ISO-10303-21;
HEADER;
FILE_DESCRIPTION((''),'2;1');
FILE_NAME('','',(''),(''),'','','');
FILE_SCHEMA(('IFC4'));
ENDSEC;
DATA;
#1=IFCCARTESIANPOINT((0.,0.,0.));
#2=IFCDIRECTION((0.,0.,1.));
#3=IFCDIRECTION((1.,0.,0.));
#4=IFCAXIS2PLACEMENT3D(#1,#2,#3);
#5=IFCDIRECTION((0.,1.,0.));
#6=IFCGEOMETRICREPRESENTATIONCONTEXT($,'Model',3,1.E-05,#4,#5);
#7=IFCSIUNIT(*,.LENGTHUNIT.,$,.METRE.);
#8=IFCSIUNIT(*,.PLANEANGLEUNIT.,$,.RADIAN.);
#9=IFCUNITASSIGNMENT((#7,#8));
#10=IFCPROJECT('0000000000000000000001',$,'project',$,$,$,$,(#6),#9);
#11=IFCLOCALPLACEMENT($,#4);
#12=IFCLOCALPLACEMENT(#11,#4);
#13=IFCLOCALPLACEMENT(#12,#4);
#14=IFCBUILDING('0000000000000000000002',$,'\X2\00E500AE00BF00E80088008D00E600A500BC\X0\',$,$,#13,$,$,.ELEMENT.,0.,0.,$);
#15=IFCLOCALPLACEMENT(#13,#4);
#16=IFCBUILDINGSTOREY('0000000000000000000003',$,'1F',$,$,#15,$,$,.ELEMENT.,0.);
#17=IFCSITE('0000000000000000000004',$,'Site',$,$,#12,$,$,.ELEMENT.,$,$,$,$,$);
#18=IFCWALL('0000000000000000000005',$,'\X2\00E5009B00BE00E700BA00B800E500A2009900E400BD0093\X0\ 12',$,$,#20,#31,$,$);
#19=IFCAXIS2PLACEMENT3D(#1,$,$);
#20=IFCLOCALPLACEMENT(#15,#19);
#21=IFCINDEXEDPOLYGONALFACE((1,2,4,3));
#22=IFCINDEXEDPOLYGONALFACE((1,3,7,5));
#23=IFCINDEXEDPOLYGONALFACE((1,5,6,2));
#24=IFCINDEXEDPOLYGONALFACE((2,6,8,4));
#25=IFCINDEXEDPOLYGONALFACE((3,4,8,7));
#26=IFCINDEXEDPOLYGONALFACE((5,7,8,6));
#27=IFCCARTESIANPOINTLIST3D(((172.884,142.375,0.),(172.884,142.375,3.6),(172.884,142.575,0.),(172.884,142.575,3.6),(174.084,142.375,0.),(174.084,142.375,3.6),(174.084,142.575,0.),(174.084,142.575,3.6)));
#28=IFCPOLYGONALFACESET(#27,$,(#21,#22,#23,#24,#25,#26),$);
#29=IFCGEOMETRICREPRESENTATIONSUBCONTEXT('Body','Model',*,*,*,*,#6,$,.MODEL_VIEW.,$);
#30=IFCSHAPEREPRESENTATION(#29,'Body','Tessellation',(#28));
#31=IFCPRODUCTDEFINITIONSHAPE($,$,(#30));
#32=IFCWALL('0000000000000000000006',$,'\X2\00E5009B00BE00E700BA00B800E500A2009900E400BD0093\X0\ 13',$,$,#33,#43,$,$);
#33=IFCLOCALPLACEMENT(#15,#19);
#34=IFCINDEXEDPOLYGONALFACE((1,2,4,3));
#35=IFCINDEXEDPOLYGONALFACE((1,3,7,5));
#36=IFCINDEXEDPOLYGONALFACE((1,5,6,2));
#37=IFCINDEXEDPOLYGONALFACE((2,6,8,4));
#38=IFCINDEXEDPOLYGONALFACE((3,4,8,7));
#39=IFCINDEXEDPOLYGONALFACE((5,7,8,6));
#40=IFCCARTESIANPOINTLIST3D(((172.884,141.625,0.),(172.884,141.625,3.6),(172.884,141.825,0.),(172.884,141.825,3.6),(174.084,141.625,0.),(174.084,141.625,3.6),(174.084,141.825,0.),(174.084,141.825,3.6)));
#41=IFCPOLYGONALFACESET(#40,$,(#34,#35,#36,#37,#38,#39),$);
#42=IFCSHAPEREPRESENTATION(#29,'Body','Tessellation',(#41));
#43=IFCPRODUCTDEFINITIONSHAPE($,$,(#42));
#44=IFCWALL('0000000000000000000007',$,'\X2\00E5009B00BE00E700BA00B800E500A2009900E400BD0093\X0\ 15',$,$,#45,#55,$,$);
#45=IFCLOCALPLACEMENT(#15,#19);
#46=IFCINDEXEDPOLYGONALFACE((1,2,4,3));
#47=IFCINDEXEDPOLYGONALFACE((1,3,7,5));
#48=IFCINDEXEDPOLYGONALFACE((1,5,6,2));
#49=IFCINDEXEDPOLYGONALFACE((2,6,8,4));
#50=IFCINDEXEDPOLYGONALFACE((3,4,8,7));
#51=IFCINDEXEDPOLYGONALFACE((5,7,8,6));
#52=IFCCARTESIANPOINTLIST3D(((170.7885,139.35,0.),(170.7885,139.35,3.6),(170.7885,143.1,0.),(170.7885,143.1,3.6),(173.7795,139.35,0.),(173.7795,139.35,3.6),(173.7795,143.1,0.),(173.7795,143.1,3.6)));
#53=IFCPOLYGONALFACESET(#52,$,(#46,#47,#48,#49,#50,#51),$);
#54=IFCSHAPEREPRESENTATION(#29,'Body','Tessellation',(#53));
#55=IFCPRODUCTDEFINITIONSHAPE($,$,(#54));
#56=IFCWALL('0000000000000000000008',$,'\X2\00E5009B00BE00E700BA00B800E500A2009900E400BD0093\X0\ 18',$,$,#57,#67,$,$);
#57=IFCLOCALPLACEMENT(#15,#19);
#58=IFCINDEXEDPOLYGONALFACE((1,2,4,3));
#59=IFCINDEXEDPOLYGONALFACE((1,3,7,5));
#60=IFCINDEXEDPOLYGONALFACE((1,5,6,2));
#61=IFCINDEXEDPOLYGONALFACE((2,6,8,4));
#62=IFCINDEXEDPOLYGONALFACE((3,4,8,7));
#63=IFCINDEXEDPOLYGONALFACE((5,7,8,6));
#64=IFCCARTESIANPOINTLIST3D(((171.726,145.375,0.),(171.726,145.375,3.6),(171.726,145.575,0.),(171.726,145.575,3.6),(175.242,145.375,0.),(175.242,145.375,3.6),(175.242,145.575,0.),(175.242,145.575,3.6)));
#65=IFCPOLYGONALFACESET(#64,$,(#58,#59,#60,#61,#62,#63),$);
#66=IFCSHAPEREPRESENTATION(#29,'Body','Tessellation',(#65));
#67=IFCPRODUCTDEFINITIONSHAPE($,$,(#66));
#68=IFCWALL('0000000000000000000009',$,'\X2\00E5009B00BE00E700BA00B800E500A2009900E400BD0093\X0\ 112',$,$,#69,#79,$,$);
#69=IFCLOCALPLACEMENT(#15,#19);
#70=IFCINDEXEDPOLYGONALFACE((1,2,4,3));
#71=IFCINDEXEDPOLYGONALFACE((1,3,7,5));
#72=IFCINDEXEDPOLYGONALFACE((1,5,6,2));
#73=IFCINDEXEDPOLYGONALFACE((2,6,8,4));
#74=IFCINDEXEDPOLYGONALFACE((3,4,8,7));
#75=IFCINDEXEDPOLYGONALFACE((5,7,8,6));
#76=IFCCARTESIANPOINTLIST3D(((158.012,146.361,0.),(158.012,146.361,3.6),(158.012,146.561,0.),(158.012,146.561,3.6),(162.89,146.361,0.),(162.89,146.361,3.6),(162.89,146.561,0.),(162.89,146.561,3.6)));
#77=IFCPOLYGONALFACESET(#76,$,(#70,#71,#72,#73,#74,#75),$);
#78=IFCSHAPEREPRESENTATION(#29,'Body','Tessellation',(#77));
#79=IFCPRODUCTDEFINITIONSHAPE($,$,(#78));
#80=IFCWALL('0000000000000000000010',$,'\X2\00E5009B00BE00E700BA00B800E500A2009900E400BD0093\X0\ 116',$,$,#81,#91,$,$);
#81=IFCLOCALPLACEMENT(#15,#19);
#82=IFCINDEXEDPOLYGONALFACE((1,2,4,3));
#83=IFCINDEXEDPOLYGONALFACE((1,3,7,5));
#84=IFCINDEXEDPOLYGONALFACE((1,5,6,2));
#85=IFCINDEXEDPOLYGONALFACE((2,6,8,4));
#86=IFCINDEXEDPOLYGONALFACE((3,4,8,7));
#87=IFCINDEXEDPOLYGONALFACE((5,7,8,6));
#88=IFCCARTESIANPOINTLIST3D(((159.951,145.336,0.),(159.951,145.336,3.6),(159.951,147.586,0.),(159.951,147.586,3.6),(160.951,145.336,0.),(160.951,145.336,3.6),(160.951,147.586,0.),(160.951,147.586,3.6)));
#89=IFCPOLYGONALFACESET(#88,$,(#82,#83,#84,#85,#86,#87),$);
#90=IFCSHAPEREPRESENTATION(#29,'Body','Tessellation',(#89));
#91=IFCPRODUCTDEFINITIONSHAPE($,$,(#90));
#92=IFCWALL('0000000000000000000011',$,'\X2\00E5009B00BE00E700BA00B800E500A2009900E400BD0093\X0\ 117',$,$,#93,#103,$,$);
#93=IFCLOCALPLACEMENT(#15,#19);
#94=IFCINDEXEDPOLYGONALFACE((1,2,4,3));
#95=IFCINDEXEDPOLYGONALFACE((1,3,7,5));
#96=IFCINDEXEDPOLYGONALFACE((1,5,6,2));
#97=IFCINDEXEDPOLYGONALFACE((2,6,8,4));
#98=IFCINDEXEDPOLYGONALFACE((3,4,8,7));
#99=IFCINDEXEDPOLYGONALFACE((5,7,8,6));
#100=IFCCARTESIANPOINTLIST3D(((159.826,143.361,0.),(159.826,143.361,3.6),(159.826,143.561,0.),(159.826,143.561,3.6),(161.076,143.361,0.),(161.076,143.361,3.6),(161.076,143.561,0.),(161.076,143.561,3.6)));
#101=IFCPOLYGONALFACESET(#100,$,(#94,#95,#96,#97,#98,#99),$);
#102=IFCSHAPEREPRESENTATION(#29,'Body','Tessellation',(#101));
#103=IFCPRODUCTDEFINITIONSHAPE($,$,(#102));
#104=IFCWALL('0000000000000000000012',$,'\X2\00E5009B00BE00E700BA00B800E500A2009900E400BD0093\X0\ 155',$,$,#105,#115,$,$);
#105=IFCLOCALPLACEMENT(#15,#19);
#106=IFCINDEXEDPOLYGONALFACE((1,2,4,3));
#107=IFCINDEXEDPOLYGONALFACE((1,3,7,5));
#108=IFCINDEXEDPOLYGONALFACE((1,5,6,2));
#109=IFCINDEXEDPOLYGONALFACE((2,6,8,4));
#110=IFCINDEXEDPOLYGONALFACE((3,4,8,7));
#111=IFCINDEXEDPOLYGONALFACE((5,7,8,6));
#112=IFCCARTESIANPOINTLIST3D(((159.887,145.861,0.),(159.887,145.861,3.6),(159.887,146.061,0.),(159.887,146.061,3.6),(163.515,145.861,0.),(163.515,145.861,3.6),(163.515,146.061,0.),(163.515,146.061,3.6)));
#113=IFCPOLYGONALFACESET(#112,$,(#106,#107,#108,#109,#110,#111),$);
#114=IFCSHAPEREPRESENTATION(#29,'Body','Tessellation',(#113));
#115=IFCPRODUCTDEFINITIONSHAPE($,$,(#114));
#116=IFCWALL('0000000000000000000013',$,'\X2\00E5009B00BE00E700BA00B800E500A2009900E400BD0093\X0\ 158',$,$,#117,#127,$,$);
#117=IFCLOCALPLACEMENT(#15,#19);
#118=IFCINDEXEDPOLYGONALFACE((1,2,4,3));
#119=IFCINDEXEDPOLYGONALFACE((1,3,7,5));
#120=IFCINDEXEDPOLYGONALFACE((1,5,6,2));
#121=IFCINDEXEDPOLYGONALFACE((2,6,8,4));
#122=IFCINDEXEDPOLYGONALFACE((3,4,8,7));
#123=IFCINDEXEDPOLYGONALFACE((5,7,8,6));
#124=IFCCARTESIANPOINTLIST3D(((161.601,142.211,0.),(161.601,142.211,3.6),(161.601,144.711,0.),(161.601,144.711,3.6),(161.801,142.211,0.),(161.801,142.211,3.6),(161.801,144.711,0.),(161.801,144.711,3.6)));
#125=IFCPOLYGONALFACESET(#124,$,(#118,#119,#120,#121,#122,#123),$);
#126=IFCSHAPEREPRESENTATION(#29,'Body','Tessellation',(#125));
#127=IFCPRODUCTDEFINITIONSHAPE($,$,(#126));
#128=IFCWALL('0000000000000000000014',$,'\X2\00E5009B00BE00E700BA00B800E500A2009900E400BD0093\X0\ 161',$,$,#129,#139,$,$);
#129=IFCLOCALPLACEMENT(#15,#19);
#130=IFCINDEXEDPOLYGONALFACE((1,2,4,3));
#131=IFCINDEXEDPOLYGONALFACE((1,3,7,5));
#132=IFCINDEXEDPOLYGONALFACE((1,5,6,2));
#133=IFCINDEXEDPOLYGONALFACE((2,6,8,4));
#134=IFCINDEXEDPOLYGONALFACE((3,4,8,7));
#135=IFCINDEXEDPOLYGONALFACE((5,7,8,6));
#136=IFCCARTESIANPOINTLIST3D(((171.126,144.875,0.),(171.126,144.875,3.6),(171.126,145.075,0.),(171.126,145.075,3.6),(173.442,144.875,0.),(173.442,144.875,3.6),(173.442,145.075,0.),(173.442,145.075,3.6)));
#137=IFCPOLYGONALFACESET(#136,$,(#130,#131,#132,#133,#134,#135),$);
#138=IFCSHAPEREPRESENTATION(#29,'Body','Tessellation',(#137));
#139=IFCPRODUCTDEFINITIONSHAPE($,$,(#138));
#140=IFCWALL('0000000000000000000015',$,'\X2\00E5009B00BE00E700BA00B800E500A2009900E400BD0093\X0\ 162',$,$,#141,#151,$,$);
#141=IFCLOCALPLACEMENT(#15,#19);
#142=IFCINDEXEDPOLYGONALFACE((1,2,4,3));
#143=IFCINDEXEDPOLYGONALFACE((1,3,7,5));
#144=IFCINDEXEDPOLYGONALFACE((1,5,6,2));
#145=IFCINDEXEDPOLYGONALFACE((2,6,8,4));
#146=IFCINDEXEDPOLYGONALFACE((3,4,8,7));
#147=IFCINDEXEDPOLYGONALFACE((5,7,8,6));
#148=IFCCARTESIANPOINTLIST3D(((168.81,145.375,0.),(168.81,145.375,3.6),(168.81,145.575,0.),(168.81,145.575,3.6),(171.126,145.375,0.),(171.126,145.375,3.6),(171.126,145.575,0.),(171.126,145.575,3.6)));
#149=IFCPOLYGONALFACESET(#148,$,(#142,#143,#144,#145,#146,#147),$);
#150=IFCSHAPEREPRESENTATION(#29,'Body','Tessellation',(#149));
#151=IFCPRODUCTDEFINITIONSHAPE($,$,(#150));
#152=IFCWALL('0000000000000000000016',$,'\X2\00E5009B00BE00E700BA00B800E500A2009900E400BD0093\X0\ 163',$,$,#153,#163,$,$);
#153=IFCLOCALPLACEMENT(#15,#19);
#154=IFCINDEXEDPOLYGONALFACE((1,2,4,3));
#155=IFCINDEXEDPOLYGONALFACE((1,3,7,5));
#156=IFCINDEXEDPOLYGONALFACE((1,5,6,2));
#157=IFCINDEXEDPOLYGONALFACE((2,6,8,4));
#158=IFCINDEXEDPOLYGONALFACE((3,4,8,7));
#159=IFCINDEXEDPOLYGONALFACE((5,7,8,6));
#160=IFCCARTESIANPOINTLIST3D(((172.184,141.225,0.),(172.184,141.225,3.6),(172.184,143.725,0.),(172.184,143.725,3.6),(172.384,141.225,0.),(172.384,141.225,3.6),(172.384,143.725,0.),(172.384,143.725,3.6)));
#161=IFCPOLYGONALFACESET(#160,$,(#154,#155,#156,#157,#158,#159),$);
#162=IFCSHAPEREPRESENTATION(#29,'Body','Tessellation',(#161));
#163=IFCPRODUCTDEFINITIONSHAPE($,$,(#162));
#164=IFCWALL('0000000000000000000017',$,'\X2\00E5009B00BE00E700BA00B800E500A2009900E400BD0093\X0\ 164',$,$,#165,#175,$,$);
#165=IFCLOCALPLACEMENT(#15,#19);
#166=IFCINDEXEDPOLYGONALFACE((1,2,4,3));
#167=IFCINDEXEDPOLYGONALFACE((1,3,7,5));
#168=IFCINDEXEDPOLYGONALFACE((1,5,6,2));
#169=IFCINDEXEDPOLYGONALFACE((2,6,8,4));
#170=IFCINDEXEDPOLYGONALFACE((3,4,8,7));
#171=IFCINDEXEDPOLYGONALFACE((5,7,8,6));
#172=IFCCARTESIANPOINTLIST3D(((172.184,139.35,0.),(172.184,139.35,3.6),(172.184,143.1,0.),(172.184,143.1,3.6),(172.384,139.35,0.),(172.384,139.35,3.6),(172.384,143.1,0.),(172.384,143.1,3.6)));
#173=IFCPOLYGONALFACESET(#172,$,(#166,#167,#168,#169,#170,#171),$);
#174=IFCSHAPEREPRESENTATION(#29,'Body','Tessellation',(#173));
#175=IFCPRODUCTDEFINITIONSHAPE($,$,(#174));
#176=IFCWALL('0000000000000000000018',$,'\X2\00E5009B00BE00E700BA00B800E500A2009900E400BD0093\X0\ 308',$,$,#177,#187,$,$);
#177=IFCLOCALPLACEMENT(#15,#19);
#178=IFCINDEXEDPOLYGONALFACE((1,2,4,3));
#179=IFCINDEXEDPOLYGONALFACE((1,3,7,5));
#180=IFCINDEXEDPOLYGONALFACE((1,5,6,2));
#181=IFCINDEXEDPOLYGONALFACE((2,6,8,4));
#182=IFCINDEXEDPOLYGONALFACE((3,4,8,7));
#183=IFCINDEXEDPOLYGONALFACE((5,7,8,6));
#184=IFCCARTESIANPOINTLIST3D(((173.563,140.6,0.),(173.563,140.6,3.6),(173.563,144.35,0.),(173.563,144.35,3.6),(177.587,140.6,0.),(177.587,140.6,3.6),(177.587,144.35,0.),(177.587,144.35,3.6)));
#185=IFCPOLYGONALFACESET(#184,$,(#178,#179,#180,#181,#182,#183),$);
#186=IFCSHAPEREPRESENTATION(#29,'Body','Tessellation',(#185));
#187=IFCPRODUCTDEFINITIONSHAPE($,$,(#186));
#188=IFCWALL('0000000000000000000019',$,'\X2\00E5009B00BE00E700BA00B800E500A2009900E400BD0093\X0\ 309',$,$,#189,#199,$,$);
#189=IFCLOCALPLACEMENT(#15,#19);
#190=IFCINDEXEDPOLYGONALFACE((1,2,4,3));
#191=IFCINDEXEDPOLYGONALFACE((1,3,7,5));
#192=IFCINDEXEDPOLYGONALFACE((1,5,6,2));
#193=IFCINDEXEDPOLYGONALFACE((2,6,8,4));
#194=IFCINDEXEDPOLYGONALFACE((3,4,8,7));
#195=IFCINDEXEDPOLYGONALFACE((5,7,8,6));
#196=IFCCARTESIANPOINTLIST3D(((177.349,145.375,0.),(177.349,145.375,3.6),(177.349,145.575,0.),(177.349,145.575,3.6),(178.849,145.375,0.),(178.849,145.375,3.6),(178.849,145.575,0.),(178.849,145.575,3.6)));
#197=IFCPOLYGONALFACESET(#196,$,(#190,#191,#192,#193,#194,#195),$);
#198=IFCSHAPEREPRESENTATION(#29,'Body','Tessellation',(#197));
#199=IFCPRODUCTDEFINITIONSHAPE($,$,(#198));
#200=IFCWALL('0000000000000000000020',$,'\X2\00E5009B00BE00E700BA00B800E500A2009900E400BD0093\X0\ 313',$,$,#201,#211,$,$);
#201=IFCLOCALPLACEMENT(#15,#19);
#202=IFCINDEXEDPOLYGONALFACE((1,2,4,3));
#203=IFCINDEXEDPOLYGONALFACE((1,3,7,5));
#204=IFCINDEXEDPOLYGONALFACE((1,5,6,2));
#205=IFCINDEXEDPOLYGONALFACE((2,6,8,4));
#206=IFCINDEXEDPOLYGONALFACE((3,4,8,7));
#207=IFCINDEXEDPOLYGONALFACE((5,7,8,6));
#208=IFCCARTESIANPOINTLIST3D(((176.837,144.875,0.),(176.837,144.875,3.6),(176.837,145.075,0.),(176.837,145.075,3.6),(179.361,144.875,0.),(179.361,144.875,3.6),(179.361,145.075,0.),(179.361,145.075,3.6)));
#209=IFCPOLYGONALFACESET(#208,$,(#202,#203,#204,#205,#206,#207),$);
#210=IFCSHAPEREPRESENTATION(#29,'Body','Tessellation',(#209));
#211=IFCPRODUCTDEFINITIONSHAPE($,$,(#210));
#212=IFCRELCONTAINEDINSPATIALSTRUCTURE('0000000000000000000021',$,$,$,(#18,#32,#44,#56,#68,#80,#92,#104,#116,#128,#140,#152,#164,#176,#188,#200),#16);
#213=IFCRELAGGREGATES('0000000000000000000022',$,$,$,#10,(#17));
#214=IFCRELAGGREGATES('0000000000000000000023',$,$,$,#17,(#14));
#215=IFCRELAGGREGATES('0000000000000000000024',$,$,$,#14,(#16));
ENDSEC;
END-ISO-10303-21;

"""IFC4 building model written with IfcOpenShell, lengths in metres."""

from ifc_helpers import new_model, si_unit, direction, frame, frame_2d, origin_with_axes, place, context, subcontext, project, spatial, rectangle, extrude, element, save


model = new_model("IFC4")

# Units and contexts
model_context = context("Model", 3, precision=1e-05, world=origin_with_axes(), true_north=direction((0.0, 1.0, 0.0)))
body_context = subcontext(model_context, "Body", "Model", "MODEL_VIEW")
ifc_project = project(units=[si_unit("LENGTHUNIT", "METRE"), si_unit("PLANEANGLEUNIT", "RADIAN")], contexts=[model_context])

# Site, building, storey
placement = place(None, origin_with_axes())
site_placement = place(placement, origin_with_axes())
site = spatial("IfcSite", under=ifc_project, at=site_placement, Name="Site", CompositionType="ELEMENT")
building_placement = place(site_placement, origin_with_axes())
building = spatial("IfcBuilding", under=site, at=building_placement, Name="å®¿è\u0088\u008dæ¥¼", CompositionType="ELEMENT", ElevationOfRefHeight=0.0, ElevationOfTerrain=0.0)
storey_placement = place(building_placement, origin_with_axes())
storey = spatial("IfcBuildingStorey", under=building, at=storey_placement, Name="1F", CompositionType="ELEMENT", Elevation=0.0)

# Walls
for number, where, z_axis, x_axis, name in (
    (1, (173.484, 142.475, 0.0), (0.0, 0.0, 1.0), (-1.0, 0.0, 0.0), "å\u009b¾çº¸å¢\u0099ä½\u0093 12"),
    (2, (173.484, 141.725, 0.0), (0.0, 0.0, 1.0), (-1.0, 0.0, 0.0), "å\u009b¾çº¸å¢\u0099ä½\u0093 13"),
):
    element("IfcWall", number, at=place(storey_placement, frame(where, z_axis=z_axis, x_axis=x_axis)), inside=storey, Name=name, context=body_context, shape_type="SweptSolid", body=[
        extrude(rectangle(XDim=1.2, YDim=0.2, at=frame_2d((0.0, 0.0), x_axis=(1.0, 0.0, 0.0))), frame((0.0, 0.0, 0.0), z_axis=(0.0, 0.0, 1.0)), (0.0, 0.0, 1.0), 3.6),
    ])
wall_1_placement = place(storey_placement, frame((172.284, 141.225, 0.0), z_axis=(0.0, 0.0, 1.0), x_axis=(1.0, 0.0, 0.0)))
element("IfcWall", 3, at=wall_1_placement, inside=storey, Name="å\u009b¾çº¸å¢\u0099ä½\u0093 15", context=body_context, shape_type="SweptSolid", body=[
    extrude(rectangle(XDim=2.991, YDim=3.75, at=frame_2d((0.0, 0.0), x_axis=(1.0, 0.0, 0.0))), frame((0.0, 0.0, 0.0), z_axis=(0.0, 0.0, 1.0)), (0.0, 0.0, 1.0), 3.6),
])
wall_2_placement = place(storey_placement, frame((173.484, 145.475, 0.0), z_axis=(0.0, 0.0, 1.0), x_axis=(-1.0, 0.0, 0.0)))
element("IfcWall", 4, at=wall_2_placement, inside=storey, Name="å\u009b¾çº¸å¢\u0099ä½\u0093 18", context=body_context, shape_type="SweptSolid", body=[
    extrude(rectangle(XDim=3.516, YDim=0.2, at=frame_2d((0.0, 0.0), x_axis=(1.0, 0.0, 0.0))), frame((0.0, 0.0, 0.0), z_axis=(0.0, 0.0, 1.0)), (0.0, 0.0, 1.0), 3.6),
])
for number, where, z_axis, x_axis, name in (
    (5, (160.451, 146.461, 0.0), (0.0, 0.0, 1.0), (1.0, 0.0, 0.0), "å\u009b¾çº¸å¢\u0099ä½\u0093 112"),
):
    element("IfcWall", number, at=place(storey_placement, frame(where, z_axis=z_axis, x_axis=x_axis)), inside=storey, Name=name, context=body_context, shape_type="SweptSolid", body=[
        extrude(rectangle(XDim=4.878, YDim=0.2, at=frame_2d((0.0, 0.0), x_axis=(1.0, 0.0, 0.0))), frame((0.0, 0.0, 0.0), z_axis=(0.0, 0.0, 1.0)), (0.0, 0.0, 1.0), 3.6),
    ])
wall_3_placement = place(storey_placement, frame((160.451, 146.461, 0.0), z_axis=(0.0, 0.0, 1.0), x_axis=(1.0, 0.0, 0.0)))
element("IfcWall", 6, at=wall_3_placement, inside=storey, Name="å\u009b¾çº¸å¢\u0099ä½\u0093 116", context=body_context, shape_type="SweptSolid", body=[
    extrude(rectangle(XDim=1.0, YDim=2.25, at=frame_2d((0.0, 0.0), x_axis=(1.0, 0.0, 0.0))), frame((0.0, 0.0, 0.0), z_axis=(0.0, 0.0, 1.0)), (0.0, 0.0, 1.0), 3.6),
])
wall_4_placement = place(storey_placement, frame((160.451, 143.461, 0.0), z_axis=(0.0, 0.0, 1.0), x_axis=(1.0, 0.0, 0.0)))
element("IfcWall", 7, at=wall_4_placement, inside=storey, Name="å\u009b¾çº¸å¢\u0099ä½\u0093 117", context=body_context, shape_type="SweptSolid", body=[
    extrude(rectangle(XDim=1.25, YDim=0.2, at=frame_2d((0.0, 0.0), x_axis=(1.0, 0.0, 0.0))), frame((0.0, 0.0, 0.0), z_axis=(0.0, 0.0, 1.0)), (0.0, 0.0, 1.0), 3.6),
])
for number, where, z_axis, x_axis, name in (
    (8, (161.701, 145.961, 0.0), (0.0, 0.0, 1.0), (1.0, 0.0, 0.0), "å\u009b¾çº¸å¢\u0099ä½\u0093 155"),
):
    element("IfcWall", number, at=place(storey_placement, frame(where, z_axis=z_axis, x_axis=x_axis)), inside=storey, Name=name, context=body_context, shape_type="SweptSolid", body=[
        extrude(rectangle(XDim=3.628, YDim=0.2, at=frame_2d((0.0, 0.0), x_axis=(1.0, 0.0, 0.0))), frame((0.0, 0.0, 0.0), z_axis=(0.0, 0.0, 1.0)), (0.0, 0.0, 1.0), 3.6),
    ])
wall_5_placement = place(storey_placement, frame((161.701, 143.461, 0.0), z_axis=(0.0, 0.0, 1.0), x_axis=(0.0, 1.0, 0.0)))
element("IfcWall", 9, at=wall_5_placement, inside=storey, Name="å\u009b¾çº¸å¢\u0099ä½\u0093 158", context=body_context, shape_type="SweptSolid", body=[
    extrude(rectangle(XDim=2.5, YDim=0.2, at=frame_2d((0.0, 0.0), x_axis=(1.0, 0.0, 0.0))), frame((0.0, 0.0, 0.0), z_axis=(0.0, 0.0, 1.0)), (0.0, 0.0, 1.0), 3.6),
])
for number, where, z_axis, x_axis, name in (
    (10, (172.284, 144.975, 0.0), (0.0, 0.0, 1.0), (-1.0, 0.0, 0.0), "å\u009b¾çº¸å¢\u0099ä½\u0093 161"),
    (11, (169.968, 145.475, 0.0), (0.0, 0.0, 1.0), (1.0, 0.0, 0.0), "å\u009b¾çº¸å¢\u0099ä½\u0093 162"),
):
    element("IfcWall", number, at=place(storey_placement, frame(where, z_axis=z_axis, x_axis=x_axis)), inside=storey, Name=name, context=body_context, shape_type="SweptSolid", body=[
        extrude(rectangle(XDim=2.316, YDim=0.2, at=frame_2d((0.0, 0.0), x_axis=(1.0, 0.0, 0.0))), frame((0.0, 0.0, 0.0), z_axis=(0.0, 0.0, 1.0)), (0.0, 0.0, 1.0), 3.6),
    ])
wall_6_placement = place(storey_placement, frame((172.284, 142.475, 0.0), z_axis=(0.0, 0.0, 1.0), x_axis=(0.0, 1.0, 0.0)))
element("IfcWall", 12, at=wall_6_placement, inside=storey, Name="å\u009b¾çº¸å¢\u0099ä½\u0093 163", context=body_context, shape_type="SweptSolid", body=[
    extrude(rectangle(XDim=2.5, YDim=0.2, at=frame_2d((0.0, 0.0), x_axis=(1.0, 0.0, 0.0))), frame((0.0, 0.0, 0.0), z_axis=(0.0, 0.0, 1.0)), (0.0, 0.0, 1.0), 3.6),
])
wall_7_placement = place(storey_placement, frame((172.284, 141.225, 0.0), z_axis=(0.0, 0.0, 1.0), x_axis=(0.0, 1.0, 0.0)))
element("IfcWall", 13, at=wall_7_placement, inside=storey, Name="å\u009b¾çº¸å¢\u0099ä½\u0093 164", context=body_context, shape_type="SweptSolid", body=[
    extrude(rectangle(XDim=3.75, YDim=0.2, at=frame_2d((0.0, 0.0), x_axis=(1.0, 0.0, 0.0))), frame((0.0, 0.0, 0.0), z_axis=(0.0, 0.0, 1.0)), (0.0, 0.0, 1.0), 3.6),
])
wall_8_placement = place(storey_placement, frame((175.575, 142.475, 0.0), z_axis=(0.0, 0.0, 1.0), x_axis=(1.0, 0.0, 0.0)))
element("IfcWall", 14, at=wall_8_placement, inside=storey, Name="å\u009b¾çº¸å¢\u0099ä½\u0093 308", context=body_context, shape_type="SweptSolid", body=[
    extrude(rectangle(XDim=4.024, YDim=3.75, at=frame_2d((0.0, 0.0), x_axis=(1.0, 0.0, 0.0))), frame((0.0, 0.0, 0.0), z_axis=(0.0, 0.0, 1.0)), (0.0, 0.0, 1.0), 3.6),
])
wall_9_placement = place(storey_placement, frame((178.099, 145.475, 0.0), z_axis=(0.0, 0.0, 1.0), x_axis=(1.0, 0.0, 0.0)))
element("IfcWall", 15, at=wall_9_placement, inside=storey, Name="å\u009b¾çº¸å¢\u0099ä½\u0093 309", context=body_context, shape_type="SweptSolid", body=[
    extrude(rectangle(XDim=1.5, YDim=0.2, at=frame_2d((0.0, 0.0), x_axis=(1.0, 0.0, 0.0))), frame((0.0, 0.0, 0.0), z_axis=(0.0, 0.0, 1.0)), (0.0, 0.0, 1.0), 3.6),
])
for number, where, z_axis, x_axis, name in (
    (16, (178.099, 144.975, 0.0), (0.0, 0.0, 1.0), (-1.0, 0.0, 0.0), "å\u009b¾çº¸å¢\u0099ä½\u0093 313"),
):
    element("IfcWall", number, at=place(storey_placement, frame(where, z_axis=z_axis, x_axis=x_axis)), inside=storey, Name=name, context=body_context, shape_type="SweptSolid", body=[
        extrude(rectangle(XDim=2.524, YDim=0.2, at=frame_2d((0.0, 0.0), x_axis=(1.0, 0.0, 0.0))), frame((0.0, 0.0, 0.0), z_axis=(0.0, 0.0, 1.0)), (0.0, 0.0, 1.0), 3.6),
    ])

save(model, "model.ifc")
